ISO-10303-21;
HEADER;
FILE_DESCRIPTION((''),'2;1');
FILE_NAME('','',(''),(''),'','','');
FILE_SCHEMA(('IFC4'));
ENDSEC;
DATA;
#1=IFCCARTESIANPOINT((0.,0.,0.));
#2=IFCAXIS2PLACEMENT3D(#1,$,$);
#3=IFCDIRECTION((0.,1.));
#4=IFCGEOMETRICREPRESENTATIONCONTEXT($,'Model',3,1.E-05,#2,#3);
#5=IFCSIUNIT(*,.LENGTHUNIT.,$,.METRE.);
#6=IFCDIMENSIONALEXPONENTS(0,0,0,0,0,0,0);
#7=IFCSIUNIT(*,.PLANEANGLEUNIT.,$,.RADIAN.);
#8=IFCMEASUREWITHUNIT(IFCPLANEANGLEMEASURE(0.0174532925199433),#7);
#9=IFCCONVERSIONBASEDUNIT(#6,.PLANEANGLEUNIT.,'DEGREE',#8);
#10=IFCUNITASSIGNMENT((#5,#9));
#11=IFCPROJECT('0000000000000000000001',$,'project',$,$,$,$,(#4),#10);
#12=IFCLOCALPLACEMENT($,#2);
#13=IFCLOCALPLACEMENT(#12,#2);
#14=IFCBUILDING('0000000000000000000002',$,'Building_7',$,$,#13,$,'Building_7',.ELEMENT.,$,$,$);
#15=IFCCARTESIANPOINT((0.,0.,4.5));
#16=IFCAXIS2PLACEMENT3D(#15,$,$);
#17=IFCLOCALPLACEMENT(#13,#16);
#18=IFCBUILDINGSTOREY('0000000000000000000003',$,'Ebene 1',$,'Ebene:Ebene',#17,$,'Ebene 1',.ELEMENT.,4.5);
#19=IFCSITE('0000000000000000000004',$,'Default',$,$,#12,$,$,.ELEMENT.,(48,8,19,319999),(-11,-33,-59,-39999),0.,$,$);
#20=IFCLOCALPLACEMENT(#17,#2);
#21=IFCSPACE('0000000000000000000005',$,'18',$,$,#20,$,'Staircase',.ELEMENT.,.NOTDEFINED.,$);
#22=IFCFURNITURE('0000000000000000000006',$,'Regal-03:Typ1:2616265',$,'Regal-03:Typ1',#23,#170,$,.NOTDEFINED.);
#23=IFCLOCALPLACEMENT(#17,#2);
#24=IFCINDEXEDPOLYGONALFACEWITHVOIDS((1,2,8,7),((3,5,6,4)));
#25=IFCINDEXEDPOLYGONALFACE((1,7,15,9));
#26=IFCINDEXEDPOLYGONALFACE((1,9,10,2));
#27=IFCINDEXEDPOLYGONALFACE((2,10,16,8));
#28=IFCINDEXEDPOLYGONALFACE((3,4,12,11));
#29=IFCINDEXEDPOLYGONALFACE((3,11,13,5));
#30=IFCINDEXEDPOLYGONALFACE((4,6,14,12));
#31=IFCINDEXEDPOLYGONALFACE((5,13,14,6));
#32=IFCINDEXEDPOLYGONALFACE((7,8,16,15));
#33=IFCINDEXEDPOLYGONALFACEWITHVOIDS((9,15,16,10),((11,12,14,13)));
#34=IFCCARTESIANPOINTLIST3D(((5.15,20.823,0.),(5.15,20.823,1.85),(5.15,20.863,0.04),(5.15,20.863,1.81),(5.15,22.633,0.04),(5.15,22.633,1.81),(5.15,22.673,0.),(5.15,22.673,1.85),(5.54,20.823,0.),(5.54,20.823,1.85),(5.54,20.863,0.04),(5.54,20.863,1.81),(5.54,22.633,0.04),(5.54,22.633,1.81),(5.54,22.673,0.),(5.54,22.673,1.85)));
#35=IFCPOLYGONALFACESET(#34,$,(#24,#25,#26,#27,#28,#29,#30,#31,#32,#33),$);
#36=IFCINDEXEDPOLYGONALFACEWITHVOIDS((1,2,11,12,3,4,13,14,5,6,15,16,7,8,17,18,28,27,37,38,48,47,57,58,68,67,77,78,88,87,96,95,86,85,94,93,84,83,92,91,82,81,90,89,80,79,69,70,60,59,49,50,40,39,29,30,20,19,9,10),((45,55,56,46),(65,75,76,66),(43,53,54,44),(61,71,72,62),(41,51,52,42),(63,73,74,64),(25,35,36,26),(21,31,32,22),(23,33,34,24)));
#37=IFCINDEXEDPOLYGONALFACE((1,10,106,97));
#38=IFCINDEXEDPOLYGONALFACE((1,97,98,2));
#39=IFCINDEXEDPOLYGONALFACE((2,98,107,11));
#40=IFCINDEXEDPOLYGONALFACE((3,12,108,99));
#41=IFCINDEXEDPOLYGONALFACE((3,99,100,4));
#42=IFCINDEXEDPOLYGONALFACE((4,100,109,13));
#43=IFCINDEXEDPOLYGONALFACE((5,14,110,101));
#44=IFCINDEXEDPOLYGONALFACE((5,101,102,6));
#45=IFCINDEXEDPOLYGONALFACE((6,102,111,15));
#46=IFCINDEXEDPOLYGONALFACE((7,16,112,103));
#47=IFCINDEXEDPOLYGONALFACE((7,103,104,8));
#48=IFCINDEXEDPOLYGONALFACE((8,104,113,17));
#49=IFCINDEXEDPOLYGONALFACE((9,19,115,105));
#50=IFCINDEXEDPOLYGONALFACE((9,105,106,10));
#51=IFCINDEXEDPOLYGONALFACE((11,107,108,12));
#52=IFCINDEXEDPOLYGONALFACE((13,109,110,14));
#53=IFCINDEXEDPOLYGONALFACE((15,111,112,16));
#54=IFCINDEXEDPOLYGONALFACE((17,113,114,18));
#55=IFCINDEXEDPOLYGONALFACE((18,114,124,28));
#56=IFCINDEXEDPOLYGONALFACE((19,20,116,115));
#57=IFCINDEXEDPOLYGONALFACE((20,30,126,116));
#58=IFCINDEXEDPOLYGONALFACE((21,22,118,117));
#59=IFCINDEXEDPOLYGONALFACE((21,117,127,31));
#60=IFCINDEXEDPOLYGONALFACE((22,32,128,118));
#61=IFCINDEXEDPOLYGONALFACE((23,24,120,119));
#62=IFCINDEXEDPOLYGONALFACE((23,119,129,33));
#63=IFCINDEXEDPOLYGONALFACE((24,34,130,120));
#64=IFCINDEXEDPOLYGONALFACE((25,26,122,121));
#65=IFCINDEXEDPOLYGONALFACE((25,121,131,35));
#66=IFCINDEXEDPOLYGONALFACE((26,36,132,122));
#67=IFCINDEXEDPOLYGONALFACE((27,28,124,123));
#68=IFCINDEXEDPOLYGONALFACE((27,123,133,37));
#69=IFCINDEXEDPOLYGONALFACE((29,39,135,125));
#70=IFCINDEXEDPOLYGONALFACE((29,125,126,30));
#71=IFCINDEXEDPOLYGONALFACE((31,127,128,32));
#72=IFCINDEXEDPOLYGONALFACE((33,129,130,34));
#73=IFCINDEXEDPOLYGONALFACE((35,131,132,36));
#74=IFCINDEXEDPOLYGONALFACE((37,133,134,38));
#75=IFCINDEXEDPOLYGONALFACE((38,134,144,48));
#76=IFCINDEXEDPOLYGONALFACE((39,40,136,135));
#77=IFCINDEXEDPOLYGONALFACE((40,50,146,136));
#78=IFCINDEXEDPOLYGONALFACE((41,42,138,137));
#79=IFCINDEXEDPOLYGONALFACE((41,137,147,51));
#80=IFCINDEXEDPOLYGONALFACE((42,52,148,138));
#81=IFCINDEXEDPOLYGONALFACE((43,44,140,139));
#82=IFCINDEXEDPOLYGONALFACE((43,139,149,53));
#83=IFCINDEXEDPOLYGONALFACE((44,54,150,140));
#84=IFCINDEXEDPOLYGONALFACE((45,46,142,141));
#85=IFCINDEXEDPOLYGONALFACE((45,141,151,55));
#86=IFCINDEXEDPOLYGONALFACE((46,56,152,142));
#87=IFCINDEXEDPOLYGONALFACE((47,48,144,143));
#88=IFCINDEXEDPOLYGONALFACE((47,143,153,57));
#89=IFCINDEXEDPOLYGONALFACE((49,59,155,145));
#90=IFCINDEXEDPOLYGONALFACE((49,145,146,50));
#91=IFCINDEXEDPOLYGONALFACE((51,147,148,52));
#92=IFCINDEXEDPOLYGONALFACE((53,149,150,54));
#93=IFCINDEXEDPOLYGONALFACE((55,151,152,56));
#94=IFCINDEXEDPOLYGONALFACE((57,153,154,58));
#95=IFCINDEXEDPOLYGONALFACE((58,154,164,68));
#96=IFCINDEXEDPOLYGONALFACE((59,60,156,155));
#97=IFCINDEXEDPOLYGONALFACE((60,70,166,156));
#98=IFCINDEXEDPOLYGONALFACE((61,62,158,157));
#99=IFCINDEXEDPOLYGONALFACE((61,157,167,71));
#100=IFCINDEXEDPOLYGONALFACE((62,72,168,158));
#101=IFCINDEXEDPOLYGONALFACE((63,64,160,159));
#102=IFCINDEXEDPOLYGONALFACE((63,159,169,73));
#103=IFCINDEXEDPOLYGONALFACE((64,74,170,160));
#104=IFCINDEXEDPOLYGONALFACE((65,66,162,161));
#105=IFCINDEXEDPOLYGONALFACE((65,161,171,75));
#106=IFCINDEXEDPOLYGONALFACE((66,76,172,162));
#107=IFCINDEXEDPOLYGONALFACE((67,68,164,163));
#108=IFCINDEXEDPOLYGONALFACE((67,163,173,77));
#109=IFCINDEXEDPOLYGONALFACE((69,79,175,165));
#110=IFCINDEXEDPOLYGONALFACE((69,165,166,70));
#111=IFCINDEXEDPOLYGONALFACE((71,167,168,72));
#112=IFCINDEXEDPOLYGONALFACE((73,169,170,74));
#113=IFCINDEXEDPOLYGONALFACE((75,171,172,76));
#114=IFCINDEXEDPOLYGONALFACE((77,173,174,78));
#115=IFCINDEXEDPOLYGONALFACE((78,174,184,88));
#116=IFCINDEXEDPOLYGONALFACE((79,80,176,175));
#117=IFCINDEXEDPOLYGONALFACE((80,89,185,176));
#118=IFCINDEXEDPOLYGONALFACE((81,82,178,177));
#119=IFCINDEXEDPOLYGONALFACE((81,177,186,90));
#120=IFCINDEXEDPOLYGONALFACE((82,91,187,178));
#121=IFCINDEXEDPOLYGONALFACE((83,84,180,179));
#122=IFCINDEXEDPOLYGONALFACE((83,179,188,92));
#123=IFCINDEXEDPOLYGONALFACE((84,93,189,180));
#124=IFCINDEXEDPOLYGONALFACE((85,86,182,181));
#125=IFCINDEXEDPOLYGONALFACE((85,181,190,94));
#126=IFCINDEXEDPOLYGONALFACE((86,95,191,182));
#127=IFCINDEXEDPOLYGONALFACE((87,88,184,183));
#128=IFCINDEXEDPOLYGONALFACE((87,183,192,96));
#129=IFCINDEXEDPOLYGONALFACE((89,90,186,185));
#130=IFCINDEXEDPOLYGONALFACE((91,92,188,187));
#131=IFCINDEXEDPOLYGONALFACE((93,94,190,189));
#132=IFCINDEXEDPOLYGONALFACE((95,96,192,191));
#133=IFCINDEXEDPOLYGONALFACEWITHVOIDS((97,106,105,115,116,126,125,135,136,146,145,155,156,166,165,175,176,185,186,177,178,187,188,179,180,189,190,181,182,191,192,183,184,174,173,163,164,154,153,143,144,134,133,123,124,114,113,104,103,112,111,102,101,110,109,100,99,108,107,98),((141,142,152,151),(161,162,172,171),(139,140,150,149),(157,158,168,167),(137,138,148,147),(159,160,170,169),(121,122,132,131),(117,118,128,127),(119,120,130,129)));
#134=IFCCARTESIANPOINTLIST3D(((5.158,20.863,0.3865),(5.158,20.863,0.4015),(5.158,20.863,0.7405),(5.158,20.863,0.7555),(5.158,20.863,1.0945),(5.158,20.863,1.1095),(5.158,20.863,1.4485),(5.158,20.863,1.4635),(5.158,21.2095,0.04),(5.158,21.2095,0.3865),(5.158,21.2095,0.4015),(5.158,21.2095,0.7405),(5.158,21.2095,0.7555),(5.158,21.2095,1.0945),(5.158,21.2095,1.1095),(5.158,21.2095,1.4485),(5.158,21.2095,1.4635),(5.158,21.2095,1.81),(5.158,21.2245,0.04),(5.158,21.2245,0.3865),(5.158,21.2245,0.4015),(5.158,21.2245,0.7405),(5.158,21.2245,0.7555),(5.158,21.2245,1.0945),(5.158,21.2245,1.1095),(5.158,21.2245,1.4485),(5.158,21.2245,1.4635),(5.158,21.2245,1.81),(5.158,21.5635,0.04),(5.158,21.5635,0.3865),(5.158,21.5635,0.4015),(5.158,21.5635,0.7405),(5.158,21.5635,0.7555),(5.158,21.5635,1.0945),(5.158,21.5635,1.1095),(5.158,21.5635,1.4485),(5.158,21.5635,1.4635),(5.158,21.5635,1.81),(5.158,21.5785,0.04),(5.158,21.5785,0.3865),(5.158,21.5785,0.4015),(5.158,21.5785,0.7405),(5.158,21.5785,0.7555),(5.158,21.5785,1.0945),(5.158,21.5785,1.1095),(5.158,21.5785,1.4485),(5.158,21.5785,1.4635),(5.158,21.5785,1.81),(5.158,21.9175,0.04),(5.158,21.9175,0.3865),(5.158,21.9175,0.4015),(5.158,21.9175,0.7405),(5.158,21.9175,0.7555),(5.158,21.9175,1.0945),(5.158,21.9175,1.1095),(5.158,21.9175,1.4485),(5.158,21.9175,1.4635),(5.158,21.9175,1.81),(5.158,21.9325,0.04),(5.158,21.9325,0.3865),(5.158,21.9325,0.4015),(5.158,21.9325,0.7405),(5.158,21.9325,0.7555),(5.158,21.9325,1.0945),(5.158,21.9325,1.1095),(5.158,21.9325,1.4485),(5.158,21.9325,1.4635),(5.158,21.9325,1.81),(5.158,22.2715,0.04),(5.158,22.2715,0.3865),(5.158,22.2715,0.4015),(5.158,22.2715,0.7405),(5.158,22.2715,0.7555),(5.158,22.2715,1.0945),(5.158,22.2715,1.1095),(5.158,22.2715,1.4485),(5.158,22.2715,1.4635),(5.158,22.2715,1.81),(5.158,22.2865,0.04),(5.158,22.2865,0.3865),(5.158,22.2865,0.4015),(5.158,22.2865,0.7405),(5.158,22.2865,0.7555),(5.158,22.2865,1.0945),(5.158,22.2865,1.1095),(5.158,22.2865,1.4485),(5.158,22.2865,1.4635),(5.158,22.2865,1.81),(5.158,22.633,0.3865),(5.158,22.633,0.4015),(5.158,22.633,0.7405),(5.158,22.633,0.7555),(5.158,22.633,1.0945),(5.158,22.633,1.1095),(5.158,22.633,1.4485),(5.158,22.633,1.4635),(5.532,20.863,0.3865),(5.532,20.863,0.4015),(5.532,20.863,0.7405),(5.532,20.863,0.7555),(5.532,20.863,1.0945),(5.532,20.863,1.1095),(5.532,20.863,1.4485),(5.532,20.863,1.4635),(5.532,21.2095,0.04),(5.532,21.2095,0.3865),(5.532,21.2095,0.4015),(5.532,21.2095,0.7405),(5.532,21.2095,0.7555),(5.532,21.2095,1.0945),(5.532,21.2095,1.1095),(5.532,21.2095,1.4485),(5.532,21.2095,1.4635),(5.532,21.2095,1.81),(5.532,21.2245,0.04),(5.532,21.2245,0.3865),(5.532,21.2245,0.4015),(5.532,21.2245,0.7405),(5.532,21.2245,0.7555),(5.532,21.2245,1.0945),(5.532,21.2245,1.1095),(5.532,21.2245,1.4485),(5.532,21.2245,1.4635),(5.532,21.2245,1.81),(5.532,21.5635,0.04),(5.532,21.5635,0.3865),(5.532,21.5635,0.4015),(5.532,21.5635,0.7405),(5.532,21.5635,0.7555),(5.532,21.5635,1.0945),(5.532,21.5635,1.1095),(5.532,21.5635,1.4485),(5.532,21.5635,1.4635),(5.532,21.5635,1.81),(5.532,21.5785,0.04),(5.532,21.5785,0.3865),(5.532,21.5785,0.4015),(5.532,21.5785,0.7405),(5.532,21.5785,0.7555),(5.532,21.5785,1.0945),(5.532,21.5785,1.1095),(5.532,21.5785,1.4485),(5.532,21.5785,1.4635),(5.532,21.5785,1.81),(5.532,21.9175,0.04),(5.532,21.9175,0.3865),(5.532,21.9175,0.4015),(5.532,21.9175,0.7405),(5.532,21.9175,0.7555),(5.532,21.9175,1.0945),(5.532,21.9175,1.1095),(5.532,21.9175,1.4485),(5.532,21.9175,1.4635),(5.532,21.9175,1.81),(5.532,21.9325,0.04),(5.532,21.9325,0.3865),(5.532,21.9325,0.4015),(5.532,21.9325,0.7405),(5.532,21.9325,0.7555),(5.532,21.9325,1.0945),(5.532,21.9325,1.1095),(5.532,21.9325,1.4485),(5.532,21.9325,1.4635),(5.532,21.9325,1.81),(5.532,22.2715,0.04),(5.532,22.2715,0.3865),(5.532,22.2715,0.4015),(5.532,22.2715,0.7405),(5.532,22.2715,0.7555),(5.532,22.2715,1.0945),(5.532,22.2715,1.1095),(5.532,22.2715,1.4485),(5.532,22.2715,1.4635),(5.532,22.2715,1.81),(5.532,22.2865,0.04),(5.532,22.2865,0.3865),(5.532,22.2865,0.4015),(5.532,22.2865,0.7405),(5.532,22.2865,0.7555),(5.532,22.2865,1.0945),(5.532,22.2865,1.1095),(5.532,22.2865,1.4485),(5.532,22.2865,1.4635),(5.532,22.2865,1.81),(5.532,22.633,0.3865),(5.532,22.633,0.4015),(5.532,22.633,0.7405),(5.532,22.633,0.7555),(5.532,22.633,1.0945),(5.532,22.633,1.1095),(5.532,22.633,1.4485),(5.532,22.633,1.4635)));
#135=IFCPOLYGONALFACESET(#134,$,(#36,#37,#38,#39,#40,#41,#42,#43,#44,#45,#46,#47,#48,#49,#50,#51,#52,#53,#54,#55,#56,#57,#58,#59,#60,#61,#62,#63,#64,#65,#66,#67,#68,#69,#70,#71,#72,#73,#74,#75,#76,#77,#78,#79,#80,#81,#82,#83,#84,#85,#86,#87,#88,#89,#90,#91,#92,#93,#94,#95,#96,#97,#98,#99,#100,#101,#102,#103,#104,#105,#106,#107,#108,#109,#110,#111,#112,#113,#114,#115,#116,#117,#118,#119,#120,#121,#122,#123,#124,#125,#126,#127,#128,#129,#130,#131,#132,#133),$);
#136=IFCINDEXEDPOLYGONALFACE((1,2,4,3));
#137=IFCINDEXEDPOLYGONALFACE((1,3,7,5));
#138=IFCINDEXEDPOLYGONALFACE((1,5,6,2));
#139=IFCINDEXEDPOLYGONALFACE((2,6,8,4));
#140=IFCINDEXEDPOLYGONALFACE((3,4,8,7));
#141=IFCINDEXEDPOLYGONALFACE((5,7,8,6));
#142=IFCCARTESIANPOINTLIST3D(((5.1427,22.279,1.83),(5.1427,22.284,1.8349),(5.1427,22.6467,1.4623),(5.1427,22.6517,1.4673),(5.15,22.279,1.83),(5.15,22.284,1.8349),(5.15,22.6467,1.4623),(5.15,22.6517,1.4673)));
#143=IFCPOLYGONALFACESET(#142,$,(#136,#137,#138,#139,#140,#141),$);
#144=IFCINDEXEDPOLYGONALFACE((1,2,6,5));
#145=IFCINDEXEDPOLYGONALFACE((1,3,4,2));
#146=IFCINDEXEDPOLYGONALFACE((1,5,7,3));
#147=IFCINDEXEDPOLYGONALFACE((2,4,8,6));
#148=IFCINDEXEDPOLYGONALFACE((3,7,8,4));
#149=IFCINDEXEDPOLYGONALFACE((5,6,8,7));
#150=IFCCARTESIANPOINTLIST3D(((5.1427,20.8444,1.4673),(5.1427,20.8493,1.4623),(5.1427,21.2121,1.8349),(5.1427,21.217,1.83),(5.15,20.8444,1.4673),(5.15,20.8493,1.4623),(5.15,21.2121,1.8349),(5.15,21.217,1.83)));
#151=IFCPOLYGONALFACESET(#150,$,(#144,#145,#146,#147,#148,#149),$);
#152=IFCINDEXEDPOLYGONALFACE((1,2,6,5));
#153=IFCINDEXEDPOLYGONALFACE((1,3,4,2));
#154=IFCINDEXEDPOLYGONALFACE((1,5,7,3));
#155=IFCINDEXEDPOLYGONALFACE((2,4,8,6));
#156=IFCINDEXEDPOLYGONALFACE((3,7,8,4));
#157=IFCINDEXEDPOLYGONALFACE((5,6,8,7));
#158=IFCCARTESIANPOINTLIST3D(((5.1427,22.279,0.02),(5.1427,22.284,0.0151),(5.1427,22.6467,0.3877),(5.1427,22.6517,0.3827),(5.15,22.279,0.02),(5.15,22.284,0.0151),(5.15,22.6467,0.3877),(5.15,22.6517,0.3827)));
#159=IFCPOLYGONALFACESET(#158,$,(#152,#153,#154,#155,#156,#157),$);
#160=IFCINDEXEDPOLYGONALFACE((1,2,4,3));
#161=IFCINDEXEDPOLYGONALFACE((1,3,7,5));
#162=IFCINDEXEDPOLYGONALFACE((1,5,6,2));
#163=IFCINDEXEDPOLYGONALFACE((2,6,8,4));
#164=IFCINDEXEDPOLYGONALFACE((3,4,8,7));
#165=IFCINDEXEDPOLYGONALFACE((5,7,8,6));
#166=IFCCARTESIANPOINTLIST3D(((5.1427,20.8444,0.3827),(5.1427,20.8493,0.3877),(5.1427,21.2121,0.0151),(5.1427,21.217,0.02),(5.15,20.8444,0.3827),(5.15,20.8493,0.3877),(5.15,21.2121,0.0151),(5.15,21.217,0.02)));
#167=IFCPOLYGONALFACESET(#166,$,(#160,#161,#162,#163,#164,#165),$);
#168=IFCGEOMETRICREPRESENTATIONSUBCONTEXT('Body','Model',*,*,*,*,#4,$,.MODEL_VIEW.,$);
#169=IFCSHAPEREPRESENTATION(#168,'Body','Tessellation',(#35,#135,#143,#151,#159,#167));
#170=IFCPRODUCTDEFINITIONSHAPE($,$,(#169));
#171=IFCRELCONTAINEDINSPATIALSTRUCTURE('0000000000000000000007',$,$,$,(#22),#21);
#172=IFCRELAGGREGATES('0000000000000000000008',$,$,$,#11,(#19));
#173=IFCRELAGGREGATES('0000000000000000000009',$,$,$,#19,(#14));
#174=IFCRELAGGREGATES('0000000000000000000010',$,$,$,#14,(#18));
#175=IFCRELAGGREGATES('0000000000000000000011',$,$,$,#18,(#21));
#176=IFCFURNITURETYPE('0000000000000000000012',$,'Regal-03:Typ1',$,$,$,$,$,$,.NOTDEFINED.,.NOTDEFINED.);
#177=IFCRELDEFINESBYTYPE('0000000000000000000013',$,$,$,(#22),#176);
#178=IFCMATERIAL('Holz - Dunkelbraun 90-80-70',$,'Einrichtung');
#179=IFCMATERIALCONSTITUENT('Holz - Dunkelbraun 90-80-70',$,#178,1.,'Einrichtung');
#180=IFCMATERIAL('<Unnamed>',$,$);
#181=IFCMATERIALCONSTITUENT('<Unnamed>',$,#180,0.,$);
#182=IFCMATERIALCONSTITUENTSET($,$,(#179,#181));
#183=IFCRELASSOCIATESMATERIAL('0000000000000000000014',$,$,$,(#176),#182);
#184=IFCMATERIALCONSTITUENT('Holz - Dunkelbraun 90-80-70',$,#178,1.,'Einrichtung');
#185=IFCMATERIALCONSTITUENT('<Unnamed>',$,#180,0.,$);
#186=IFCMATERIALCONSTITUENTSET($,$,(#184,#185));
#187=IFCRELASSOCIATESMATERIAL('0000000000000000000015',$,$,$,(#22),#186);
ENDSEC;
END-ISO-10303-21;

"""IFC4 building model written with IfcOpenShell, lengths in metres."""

from ifc_helpers import new_model, entity, si_unit, converted_unit, direction, frame, origin, place, context, subcontext, project, spatial, indexed_curve, outline, extrude, source, transform, mapped, material, constituent, constituent_set, type_object, type_shapes, element, save


model = new_model("IFC4")

# Units and contexts
model_context = context("Model", 3, precision=1e-05, world=origin(), true_north=direction((0.0, 1.0)))
body_context = subcontext(model_context, "Body", "Model", "MODEL_VIEW")
ifc_project = project(units=[si_unit("LENGTHUNIT", "METRE"), converted_unit("PLANEANGLEUNIT", "DEGREE", entity("IfcPlaneAngleMeasure", 0.0174532925199433), si_unit("PLANEANGLEUNIT", "RADIAN"), dimensions=[0, 0, 0, 0, 0, 0, 0])], contexts=[model_context])

# Site, building, storey
site_placement = place(None, origin())
site = spatial("IfcSite", under=ifc_project, at=site_placement, Name="Default", CompositionType="ELEMENT", RefLatitude=(48, 8, 19, 319999), RefLongitude=(-11, -33, -59, -39999), RefElevation=0.0)
building_placement = place(site_placement, origin())
building = spatial("IfcBuilding", under=site, at=building_placement, Name="Building_7", LongName="Building_7", CompositionType="ELEMENT")
storey_placement = place(building_placement, frame((0.0, 0.0, 4.5)))
storey = spatial("IfcBuildingStorey", under=building, at=storey_placement, Name="Ebene 1", ObjectType="Ebene:Ebene", LongName="Ebene 1", CompositionType="ELEMENT", Elevation=4.5)

# Shared definitions
ifc_material_1 = material(Name="<Unnamed>")

# Shared definitions
ifc_material_2 = material(Name="Holz - Dunkelbraun 90-80-70", Category="Einrichtung")
ifc_constituent_1 = constituent(ifc_material_2, Name="Holz - Dunkelbraun 90-80-70", Category="Einrichtung", fraction=1.0)
ifc_constituent_2 = constituent(ifc_material_1, Name="<Unnamed>", fraction=0.0)
ifc_constituent_set_1 = constituent_set(constituents=[ifc_constituent_1, ifc_constituent_2])
furniture_type_1 = type_object("IfcFurnitureType", Name="Regal-03:Typ1", AssemblyPlace="NOTDEFINED", PredefinedType="NOTDEFINED", material=ifc_constituent_set_1)
shared_shape_1 = source(origin(), body_context, "Body", "SweptSolid", [
    extrude(outline(indexed_curve([(-0.925, -0.925), (0.925, -0.925), (0.925, 0.925), (-0.925, 0.925), (-0.925, -0.925)], self_intersect=False), holes=[indexed_curve([(-0.885, -0.885), (-0.885, 0.885), (0.885, 0.885), (0.885, -0.885), (-0.885, -0.885)], self_intersect=False)]), frame((0.2471, -0.2651, 0.925), z_axis=(0.0, 1.0, 0.0), x_axis=(0.0, 0.0, -1.0)), (0.0, 0.0, 1.0), 0.39),
    extrude(outline(indexed_curve([(0.5385, -0.5385), (0.885, -0.5385), (0.885, -0.5235), (0.5385, -0.5235), (0.5385, -0.1845), (0.885, -0.1845), (0.885, -0.1695), (0.5385, -0.1695), (0.5385, 0.1695), (0.885, 0.1695), (0.885, 0.1845), (0.5385, 0.1845), (0.5385, 0.5235), (0.885, 0.5235), (0.885, 0.5385), (0.5385, 0.5385), (0.5385, 0.885), (0.5235, 0.885), (0.5235, 0.5385), (0.1845, 0.5385), (0.1845, 0.885), (0.1695, 0.885), (0.1695, 0.5385), (-0.1695, 0.5385), (-0.1695, 0.885), (-0.1845, 0.885), (-0.1845, 0.5385), (-0.5235, 0.5385), (-0.5235, 0.885), (-0.5385, 0.885), (-0.5385, 0.5385), (-0.885, 0.5385), (-0.885, 0.5235), (-0.5385, 0.5235), (-0.5385, 0.1845), (-0.885, 0.1845), (-0.885, 0.1695), (-0.5385, 0.1695), (-0.5385, -0.1695), (-0.885, -0.1695), (-0.885, -0.1845), (-0.5385, -0.1845), (-0.5385, -0.5235), (-0.885, -0.5235), (-0.885, -0.5385), (-0.5385, -0.5385), (-0.5385, -0.885), (-0.5235, -0.885), (-0.5235, -0.5385), (-0.1845, -0.5385), (-0.1845, -0.885), (-0.1695, -0.885), (-0.1695, -0.5385), (0.1695, -0.5385), (0.1695, -0.885), (0.1845, -0.885), (0.1845, -0.5385), (0.5235, -0.5385), (0.5235, -0.885), (0.5385, -0.885), (0.5385, -0.5385)], self_intersect=False), holes=[indexed_curve([(0.5235, -0.1845), (0.5235, -0.5235), (0.1845, -0.5235), (0.1845, -0.1845), (0.5235, -0.1845)], self_intersect=False), indexed_curve([(0.1845, -0.1695), (0.1845, 0.1695), (0.5235, 0.1695), (0.5235, -0.1695), (0.1845, -0.1695)], self_intersect=False), indexed_curve([(0.1845, 0.1845), (0.1845, 0.5235), (0.5235, 0.5235), (0.5235, 0.1845), (0.1845, 0.1845)], self_intersect=False), indexed_curve([(-0.1695, 0.5235), (0.1695, 0.5235), (0.1695, 0.1845), (-0.1695, 0.1845), (-0.1695, 0.5235)], self_intersect=False), indexed_curve([(-0.1695, 0.1695), (0.1695, 0.1695), (0.1695, -0.1695), (-0.1695, -0.1695), (-0.1695, 0.1695)], self_intersect=False), indexed_curve([(-0.1695, -0.1845), (0.1695, -0.1845), (0.1695, -0.5235), (-0.1695, -0.5235), (-0.1695, -0.1845)], self_intersect=False), indexed_curve([(-0.5235, -0.5235), (-0.5235, -0.1845), (-0.1845, -0.1845), (-0.1845, -0.5235), (-0.5235, -0.5235)], self_intersect=False), indexed_curve([(-0.5235, -0.1695), (-0.5235, 0.1695), (-0.1845, 0.1695), (-0.1845, -0.1695), (-0.5235, -0.1695)], self_intersect=False), indexed_curve([(-0.5235, 0.1845), (-0.5235, 0.5235), (-0.1845, 0.5235), (-0.1845, 0.1845), (-0.5235, 0.1845)], self_intersect=False)]), frame((0.2471, -0.2571, 0.925), z_axis=(0.0, 1.0, 0.0), x_axis=(0.0, 0.0, 1.0)), (0.0, 0.0, 1.0), 0.374),
    extrude(outline(indexed_curve([(-0.0037, -0.0035), (0.0037, -0.0035), (0.0037, 0.0035), (-0.0037, 0.0035), (-0.0037, -0.0035)], self_intersect=False)), frame((1.1482, 0.1286, 1.4648), z_axis=(-0.707107, 0.0, 0.707107), x_axis=(0.0, 1.0, 0.0)), (0.0, 0.0, 1.0), 0.52),
    extrude(outline(indexed_curve([(-0.0037, -0.0035), (0.0037, -0.0035), (0.0037, 0.0035), (-0.0037, 0.0035), (-0.0037, -0.0035)], self_intersect=False)), frame((-0.6541, 0.1286, 1.4648), z_axis=(0.707107, 0.0, 0.707107), x_axis=(0.0, 1.0, 0.0)), (0.0, 0.0, 1.0), 0.52),
    extrude(outline(indexed_curve([(-0.0037, -0.0035), (0.0037, -0.0035), (0.0037, 0.0035), (-0.0037, 0.0035), (-0.0037, -0.0035)], self_intersect=False)), frame((0.7805, 0.1286, 0.0175), z_axis=(0.707107, 0.0, 0.707107), x_axis=(0.0, 1.0, 0.0)), (0.0, 0.0, 1.0), 0.52),
    extrude(outline(indexed_curve([(-0.0037, -0.0035), (0.0037, -0.0035), (0.0037, 0.0035), (-0.0037, 0.0035), (-0.0037, -0.0035)], self_intersect=False)), frame((-0.2864, 0.1286, 0.0175), z_axis=(-0.707107, 0.0, 0.707107), x_axis=(0.0, 1.0, 0.0)), (0.0, 0.0, 1.0), 0.52),
])
type_shapes(furniture_type_1, [shared_shape_1])

# Shared definitions
space_1_placement = place(storey_placement, origin())
space_1 = spatial("IfcSpace", under=storey, at=space_1_placement, Name="18", LongName="Staircase", CompositionType="ELEMENT", PredefinedType="NOTDEFINED")

# Furniture
ifc_constituent_3 = constituent(ifc_material_2, Name="Holz - Dunkelbraun 90-80-70", Category="Einrichtung", fraction=1.0)
ifc_constituent_4 = constituent(ifc_material_1, Name="<Unnamed>", fraction=0.0)
ifc_constituent_set_2 = constituent_set(constituents=[ifc_constituent_3, ifc_constituent_4])
furniture_1_placement = place(space_1_placement, frame((5.2749, 21.501, 0.0), z_axis=(0.0, 0.0, 1.0), x_axis=(0.0, 1.0, 0.0)))
element("IfcFurniture", 1, at=furniture_1_placement, inside=space_1, type_object=furniture_type_1, material=ifc_constituent_set_2, Name="Regal-03:Typ1:2616265", ObjectType="Regal-03:Typ1", PredefinedType="NOTDEFINED", context=body_context, shape_type="MappedRepresentation", body=[
    mapped(shared_shape_1, transform((0.0, 0.0, 0.0), scale=1.0)),
])

save(model, "model.ifc")
